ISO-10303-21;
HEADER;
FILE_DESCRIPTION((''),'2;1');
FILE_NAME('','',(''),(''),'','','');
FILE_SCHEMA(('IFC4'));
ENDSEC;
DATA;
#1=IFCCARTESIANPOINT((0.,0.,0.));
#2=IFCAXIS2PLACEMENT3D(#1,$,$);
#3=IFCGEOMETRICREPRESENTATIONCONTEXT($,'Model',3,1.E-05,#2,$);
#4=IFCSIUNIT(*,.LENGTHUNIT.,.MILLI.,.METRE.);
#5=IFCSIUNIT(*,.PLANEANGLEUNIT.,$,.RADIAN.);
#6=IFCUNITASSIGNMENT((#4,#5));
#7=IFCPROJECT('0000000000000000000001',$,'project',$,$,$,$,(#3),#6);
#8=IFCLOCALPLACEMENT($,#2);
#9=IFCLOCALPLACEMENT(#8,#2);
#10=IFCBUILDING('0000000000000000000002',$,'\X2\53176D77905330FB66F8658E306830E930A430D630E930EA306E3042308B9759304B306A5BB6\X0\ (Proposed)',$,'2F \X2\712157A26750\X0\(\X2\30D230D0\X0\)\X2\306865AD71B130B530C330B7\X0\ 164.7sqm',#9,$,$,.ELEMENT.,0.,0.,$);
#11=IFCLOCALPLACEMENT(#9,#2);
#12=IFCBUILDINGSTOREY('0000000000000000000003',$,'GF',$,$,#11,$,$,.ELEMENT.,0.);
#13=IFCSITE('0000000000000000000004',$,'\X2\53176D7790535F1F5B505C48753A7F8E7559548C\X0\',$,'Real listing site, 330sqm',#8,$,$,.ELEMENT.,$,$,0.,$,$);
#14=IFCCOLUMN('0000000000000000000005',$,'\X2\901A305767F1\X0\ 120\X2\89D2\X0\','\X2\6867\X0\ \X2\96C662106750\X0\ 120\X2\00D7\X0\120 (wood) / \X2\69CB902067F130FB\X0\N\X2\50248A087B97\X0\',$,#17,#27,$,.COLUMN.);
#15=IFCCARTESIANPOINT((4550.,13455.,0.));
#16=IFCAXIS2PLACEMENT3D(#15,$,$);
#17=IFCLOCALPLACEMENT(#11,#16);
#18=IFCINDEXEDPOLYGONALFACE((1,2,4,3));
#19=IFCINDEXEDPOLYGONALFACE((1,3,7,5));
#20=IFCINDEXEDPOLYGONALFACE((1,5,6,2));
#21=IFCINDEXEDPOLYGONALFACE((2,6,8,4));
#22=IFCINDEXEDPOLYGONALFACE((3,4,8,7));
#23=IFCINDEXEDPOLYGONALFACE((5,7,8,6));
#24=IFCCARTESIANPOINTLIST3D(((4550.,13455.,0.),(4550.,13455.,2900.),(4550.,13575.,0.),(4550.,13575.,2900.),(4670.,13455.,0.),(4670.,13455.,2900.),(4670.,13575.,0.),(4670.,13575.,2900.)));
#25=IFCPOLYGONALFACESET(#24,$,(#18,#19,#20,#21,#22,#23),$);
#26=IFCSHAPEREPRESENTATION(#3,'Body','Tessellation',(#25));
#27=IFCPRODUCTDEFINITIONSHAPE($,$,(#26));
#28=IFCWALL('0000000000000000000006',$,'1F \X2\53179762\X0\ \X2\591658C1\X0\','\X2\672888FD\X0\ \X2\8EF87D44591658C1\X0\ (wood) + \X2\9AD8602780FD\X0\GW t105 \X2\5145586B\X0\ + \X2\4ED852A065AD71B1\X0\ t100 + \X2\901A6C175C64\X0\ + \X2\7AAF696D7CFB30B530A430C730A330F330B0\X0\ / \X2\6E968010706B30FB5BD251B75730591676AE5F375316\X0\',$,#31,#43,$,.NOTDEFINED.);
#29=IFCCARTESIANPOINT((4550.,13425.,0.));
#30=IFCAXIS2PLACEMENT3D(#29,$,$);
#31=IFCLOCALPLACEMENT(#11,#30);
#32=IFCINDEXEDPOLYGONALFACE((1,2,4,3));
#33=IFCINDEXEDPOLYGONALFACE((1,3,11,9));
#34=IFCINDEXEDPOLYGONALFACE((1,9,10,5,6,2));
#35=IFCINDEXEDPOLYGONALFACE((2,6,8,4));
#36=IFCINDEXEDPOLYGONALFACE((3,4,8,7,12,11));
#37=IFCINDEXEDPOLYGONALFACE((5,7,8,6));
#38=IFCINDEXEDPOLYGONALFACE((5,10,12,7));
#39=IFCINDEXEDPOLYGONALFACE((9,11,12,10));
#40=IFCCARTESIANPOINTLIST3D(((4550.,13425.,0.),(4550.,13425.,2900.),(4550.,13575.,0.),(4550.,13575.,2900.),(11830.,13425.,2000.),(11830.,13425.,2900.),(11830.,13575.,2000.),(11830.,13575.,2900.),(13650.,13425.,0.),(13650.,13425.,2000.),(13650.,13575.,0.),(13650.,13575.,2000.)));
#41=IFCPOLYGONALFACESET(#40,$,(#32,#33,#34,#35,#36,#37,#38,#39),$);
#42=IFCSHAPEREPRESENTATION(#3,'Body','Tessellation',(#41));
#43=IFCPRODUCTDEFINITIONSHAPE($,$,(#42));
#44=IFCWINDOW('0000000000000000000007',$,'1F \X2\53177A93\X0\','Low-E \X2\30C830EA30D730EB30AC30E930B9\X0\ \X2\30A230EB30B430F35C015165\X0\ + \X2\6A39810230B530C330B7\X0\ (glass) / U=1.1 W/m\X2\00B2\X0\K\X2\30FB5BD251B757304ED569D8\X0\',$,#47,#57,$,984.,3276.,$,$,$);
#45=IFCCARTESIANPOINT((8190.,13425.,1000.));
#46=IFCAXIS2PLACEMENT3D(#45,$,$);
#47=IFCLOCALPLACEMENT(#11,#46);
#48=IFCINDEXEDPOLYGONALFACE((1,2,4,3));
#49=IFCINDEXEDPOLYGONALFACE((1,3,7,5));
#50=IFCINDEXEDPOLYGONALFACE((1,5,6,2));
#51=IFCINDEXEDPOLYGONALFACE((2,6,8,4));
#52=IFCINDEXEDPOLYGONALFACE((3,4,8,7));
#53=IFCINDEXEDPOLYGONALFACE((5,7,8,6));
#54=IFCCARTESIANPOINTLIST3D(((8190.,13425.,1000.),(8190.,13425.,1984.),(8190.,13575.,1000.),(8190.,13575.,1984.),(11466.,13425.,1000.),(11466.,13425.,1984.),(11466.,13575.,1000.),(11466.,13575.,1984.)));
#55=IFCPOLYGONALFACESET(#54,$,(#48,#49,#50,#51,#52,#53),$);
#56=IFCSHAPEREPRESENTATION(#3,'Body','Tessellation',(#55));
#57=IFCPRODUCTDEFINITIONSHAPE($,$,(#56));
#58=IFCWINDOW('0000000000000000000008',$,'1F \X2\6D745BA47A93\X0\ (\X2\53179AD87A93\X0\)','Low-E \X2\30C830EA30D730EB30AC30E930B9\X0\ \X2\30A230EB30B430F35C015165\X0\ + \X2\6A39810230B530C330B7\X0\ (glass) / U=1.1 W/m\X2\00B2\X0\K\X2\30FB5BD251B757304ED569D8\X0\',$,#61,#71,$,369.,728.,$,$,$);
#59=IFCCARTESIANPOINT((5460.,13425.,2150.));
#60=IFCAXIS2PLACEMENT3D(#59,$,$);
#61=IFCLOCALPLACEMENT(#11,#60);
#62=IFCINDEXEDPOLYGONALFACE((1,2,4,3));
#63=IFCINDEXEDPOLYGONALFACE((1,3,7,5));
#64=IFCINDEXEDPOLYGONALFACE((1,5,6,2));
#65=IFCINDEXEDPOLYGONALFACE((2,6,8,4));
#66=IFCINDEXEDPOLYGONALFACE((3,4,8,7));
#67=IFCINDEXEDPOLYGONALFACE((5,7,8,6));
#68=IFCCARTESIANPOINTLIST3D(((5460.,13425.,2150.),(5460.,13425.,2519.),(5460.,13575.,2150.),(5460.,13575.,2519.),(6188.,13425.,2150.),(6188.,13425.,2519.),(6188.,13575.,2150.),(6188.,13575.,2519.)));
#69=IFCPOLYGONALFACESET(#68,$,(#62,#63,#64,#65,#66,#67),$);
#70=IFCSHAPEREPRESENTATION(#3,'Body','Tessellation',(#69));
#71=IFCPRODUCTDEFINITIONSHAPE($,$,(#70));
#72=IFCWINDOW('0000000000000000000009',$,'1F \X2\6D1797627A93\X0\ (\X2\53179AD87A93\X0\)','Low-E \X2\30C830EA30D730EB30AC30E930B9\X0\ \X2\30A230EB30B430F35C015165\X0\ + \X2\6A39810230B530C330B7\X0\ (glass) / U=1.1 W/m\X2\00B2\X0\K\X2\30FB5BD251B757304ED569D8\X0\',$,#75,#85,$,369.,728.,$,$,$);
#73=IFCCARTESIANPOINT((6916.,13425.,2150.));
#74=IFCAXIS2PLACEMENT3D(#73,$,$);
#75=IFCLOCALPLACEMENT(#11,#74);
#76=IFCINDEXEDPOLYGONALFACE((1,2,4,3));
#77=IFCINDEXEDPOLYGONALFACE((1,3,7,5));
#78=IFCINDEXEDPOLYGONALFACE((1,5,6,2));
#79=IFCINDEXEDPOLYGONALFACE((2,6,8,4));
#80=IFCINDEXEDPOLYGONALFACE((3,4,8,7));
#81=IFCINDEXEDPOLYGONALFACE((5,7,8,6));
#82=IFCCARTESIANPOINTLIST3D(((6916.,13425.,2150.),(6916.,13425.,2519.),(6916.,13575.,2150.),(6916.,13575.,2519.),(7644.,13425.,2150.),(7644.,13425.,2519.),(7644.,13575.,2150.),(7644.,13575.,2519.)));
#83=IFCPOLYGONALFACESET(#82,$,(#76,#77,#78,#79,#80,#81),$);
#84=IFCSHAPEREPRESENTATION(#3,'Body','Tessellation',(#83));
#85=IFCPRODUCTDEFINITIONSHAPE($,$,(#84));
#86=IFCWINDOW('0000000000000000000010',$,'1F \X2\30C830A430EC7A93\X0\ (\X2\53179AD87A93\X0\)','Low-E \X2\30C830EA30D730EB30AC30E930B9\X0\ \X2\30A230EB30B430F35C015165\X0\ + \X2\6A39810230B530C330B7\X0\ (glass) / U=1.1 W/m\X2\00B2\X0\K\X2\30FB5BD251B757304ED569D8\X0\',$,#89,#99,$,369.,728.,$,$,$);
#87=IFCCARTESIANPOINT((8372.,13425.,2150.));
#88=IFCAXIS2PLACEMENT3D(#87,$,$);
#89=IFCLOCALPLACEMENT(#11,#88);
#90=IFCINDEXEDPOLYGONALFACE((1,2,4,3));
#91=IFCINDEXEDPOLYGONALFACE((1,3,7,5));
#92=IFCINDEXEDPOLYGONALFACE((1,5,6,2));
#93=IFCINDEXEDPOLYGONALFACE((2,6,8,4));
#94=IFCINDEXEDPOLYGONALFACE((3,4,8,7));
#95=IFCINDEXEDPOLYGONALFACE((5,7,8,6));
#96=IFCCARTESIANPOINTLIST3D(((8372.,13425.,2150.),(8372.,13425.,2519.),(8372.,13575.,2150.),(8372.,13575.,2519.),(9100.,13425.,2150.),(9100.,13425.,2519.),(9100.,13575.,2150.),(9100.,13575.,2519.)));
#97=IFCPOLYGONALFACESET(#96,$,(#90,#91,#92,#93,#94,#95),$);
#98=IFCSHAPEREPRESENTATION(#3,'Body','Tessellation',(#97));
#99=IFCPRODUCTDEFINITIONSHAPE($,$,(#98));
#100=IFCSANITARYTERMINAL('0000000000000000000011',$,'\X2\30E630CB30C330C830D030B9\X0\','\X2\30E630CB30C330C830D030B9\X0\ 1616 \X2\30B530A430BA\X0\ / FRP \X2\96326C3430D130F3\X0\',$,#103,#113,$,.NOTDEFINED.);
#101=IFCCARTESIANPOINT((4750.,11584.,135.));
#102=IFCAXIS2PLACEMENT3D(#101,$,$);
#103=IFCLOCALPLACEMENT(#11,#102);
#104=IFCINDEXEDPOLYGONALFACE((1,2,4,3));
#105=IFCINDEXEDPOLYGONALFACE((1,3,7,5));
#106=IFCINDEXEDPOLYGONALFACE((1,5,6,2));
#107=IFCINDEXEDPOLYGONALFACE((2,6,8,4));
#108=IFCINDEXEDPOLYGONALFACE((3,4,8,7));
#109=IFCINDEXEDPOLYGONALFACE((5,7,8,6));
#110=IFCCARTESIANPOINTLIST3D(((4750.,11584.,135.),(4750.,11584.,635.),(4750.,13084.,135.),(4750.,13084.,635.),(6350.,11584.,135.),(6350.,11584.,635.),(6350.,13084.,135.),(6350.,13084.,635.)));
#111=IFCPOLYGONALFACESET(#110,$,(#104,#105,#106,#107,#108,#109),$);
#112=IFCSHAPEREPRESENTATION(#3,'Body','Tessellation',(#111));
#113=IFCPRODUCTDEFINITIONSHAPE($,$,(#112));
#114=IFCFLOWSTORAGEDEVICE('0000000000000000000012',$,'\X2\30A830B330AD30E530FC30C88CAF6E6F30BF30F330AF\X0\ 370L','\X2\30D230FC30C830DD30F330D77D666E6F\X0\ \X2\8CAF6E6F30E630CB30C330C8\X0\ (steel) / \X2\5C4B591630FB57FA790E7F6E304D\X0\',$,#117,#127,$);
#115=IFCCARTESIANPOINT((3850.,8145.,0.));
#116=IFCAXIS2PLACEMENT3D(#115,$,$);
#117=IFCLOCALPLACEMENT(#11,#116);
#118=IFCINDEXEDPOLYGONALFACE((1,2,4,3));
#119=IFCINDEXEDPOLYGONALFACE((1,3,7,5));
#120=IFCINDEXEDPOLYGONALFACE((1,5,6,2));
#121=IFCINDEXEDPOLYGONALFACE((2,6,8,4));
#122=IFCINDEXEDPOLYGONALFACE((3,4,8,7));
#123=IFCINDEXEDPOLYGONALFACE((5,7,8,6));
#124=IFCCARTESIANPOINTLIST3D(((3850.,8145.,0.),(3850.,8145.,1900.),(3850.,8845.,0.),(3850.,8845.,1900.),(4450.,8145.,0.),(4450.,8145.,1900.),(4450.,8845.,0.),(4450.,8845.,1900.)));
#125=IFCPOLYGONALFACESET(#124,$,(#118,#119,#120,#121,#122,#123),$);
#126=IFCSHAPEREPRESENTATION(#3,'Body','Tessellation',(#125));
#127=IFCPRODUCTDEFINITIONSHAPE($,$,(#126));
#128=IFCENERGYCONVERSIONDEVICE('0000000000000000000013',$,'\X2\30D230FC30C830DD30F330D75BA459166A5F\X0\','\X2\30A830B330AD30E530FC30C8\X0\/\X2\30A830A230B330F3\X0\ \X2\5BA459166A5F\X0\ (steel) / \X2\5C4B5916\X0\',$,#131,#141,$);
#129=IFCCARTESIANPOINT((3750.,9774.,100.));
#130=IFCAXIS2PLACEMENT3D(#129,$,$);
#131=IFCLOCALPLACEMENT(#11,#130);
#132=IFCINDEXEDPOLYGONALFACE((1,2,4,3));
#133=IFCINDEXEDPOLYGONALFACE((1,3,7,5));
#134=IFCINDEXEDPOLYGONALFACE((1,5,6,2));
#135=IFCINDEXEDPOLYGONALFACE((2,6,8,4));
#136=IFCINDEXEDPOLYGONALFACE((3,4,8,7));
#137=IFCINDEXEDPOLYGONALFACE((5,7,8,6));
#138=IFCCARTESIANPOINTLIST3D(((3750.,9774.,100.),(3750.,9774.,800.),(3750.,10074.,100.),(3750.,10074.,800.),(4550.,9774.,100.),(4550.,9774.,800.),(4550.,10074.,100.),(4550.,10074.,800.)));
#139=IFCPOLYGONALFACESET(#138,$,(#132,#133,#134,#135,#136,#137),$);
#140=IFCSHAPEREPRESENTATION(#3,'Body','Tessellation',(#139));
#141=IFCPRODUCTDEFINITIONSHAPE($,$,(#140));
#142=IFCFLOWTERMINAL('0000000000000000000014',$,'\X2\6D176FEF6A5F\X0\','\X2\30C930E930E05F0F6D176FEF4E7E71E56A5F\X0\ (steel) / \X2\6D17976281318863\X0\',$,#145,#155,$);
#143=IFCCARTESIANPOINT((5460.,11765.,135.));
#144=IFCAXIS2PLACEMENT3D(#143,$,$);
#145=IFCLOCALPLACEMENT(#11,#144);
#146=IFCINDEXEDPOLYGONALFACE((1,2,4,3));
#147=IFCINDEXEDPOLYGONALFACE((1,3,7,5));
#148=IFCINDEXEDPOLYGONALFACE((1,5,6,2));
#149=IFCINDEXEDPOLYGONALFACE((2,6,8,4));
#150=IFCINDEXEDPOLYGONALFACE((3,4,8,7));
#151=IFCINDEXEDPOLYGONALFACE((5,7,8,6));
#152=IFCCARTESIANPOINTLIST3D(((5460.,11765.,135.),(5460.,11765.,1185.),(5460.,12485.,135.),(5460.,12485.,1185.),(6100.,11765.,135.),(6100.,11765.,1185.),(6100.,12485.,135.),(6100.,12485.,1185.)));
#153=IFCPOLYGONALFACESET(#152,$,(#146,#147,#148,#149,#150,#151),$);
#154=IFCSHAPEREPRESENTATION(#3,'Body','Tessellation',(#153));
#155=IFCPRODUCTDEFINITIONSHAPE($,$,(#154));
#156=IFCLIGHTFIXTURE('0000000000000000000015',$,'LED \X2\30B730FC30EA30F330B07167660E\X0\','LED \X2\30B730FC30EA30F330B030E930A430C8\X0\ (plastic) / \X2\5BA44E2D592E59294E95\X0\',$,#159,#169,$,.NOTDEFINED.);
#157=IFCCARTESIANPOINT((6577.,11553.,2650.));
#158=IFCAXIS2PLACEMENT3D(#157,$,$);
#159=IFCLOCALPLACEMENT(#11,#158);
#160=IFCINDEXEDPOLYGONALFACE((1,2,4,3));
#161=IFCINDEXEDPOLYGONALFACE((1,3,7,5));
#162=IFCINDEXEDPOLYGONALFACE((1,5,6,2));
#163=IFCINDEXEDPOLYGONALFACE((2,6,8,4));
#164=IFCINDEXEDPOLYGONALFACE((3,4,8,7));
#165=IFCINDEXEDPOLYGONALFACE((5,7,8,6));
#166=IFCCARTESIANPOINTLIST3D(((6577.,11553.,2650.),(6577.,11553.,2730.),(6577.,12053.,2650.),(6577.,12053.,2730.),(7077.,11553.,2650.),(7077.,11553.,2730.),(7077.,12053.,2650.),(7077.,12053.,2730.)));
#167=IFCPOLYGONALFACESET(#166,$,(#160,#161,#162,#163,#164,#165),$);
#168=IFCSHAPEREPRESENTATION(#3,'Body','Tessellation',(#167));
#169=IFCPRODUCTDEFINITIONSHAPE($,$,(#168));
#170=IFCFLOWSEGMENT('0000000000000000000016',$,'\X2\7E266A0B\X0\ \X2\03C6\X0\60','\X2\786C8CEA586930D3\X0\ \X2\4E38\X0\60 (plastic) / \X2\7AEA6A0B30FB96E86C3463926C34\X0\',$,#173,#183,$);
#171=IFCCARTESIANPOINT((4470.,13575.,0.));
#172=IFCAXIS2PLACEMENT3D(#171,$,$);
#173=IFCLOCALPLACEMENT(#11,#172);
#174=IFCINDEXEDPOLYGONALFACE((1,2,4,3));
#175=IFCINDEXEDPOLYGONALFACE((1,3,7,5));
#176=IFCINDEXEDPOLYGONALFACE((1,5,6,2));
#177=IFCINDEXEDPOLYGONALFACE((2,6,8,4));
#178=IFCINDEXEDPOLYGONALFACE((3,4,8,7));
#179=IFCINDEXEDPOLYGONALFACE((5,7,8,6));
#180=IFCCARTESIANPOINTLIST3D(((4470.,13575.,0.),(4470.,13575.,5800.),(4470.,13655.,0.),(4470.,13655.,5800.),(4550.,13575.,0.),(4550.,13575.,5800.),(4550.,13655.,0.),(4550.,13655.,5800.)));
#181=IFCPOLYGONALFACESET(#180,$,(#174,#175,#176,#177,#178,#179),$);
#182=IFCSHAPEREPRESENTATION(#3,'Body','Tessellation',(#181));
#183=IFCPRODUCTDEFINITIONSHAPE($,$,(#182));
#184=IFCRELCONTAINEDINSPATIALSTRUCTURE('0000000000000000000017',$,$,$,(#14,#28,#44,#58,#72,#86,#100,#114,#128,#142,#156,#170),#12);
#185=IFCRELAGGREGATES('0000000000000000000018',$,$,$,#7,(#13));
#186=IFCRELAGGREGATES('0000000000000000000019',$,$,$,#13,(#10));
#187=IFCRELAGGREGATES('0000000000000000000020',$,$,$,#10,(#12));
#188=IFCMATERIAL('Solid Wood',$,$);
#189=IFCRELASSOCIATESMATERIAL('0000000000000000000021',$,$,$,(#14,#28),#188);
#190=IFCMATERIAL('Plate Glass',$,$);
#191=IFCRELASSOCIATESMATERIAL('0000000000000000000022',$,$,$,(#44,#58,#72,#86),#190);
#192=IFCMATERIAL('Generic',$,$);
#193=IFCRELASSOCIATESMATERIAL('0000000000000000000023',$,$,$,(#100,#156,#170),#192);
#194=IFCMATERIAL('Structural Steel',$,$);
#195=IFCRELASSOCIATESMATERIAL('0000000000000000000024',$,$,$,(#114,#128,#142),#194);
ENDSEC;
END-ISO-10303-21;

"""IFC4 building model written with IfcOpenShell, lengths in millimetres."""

from ifc_helpers import new_model, si_unit, frame, frame_2d, origin, place, context, project, spatial, rectangle, extrude, material, element, fill, save


model = new_model("IFC4")

# Units and contexts
model_context = context("Model", 3, precision=1e-05, world=origin())
ifc_project = project(units=[si_unit("LENGTHUNIT", "METRE", prefix="MILLI"), si_unit("PLANEANGLEUNIT", "RADIAN")], contexts=[model_context])

# Site, building, storey
site_placement = place(None, origin())
site = spatial("IfcSite", under=ifc_project, at=site_placement, Name="北海道弟子屈町美留和", ObjectType="Real listing site, 330sqm", CompositionType="ELEMENT", RefElevation=0.0)
building_placement = place(site_placement, origin())
building = spatial("IfcBuilding", under=site, at=building_placement, Name="北海道・書斎とライブラリのある静かな家 (Proposed)", ObjectType="2F 無垢材(ヒバ)と断熱サッシ 164.7sqm", CompositionType="ELEMENT", ElevationOfRefHeight=0.0, ElevationOfTerrain=0.0)
storey_placement = place(building_placement, origin())
storey = spatial("IfcBuildingStorey", under=building, at=storey_placement, Name="GF", CompositionType="ELEMENT", Elevation=0.0)

# Column
ifc_material_1 = material(Name="Solid Wood")
column_1_placement = place(storey_placement, frame((4550.0, 13455.0, 0.0)))
element("IfcColumn", 1, at=column_1_placement, inside=storey, material=ifc_material_1, Name="通し柱 120角", Description="桧 集成材 120×120 (wood) / 構造柱・N値計算", PredefinedType="COLUMN", context=model_context, shape_type="SweptSolid", body=[
    extrude(rectangle(XDim=120.0, YDim=120.0, at=frame_2d((60.0, 60.0))), frame((4550.0, 13455.0, 0.0)), (0.0, 0.0, 1.0), 2900.0),
])

# Wall, openings, windows
wall_1_placement = place(storey_placement, frame((4550.0, 13425.0, 0.0)))
wall_1 = element("IfcWall", 2, at=wall_1_placement, inside=storey, material=ifc_material_1, Name="1F 北面 外壁", Description="木製 軸組外壁 (wood) + 高性能GW t105 充填 + 付加断熱 t100 + 通気層 + 窯業系サイディング / 準耐火・寒冷地外皮強化", PredefinedType="NOTDEFINED", context=model_context, shape_type="SweptSolid", body=[
    extrude(rectangle(XDim=9100.0, YDim=150.0, at=frame_2d((4550.0, 75.0))), frame((4550.0, 13425.0, 0.0)), (0.0, 0.0, 1.0), 2900.0),
])
opening_1_placement = place(storey_placement, frame((8190.0, 13425.0, 1000.0)))
opening_1 = element("IfcOpeningElement", 3, at=opening_1_placement, cuts=wall_1, PredefinedType="NOTDEFINED", context=model_context, shape_type="SweptSolid", body=[
    extrude(rectangle(XDim=3276.0, YDim=150.0, at=frame_2d((1638.0, 75.0))), frame((8190.0, 13425.0, 1000.0)), (0.0, 0.0, 1.0), 984.0),
])
opening_2_placement = place(storey_placement, frame((5460.0, 13425.0, 2150.0)))
opening_2 = element("IfcOpeningElement", 4, at=opening_2_placement, cuts=wall_1, PredefinedType="NOTDEFINED", context=model_context, shape_type="SweptSolid", body=[
    extrude(rectangle(XDim=728.0, YDim=150.0, at=frame_2d((364.0, 75.0))), frame((5460.0, 13425.0, 2150.0)), (0.0, 0.0, 1.0), 369.0),
])
opening_3_placement = place(storey_placement, frame((6916.0, 13425.0, 2150.0)))
opening_3 = element("IfcOpeningElement", 5, at=opening_3_placement, cuts=wall_1, PredefinedType="NOTDEFINED", context=model_context, shape_type="SweptSolid", body=[
    extrude(rectangle(XDim=728.0, YDim=150.0, at=frame_2d((364.0, 75.0))), frame((6916.0, 13425.0, 2150.0)), (0.0, 0.0, 1.0), 369.0),
])
opening_4_placement = place(storey_placement, frame((8372.0, 13425.0, 2150.0)))
opening_4 = element("IfcOpeningElement", 6, at=opening_4_placement, cuts=wall_1, PredefinedType="NOTDEFINED", context=model_context, shape_type="SweptSolid", body=[
    extrude(rectangle(XDim=728.0, YDim=150.0, at=frame_2d((364.0, 75.0))), frame((8372.0, 13425.0, 2150.0)), (0.0, 0.0, 1.0), 369.0),
])
ifc_material_2 = material(Name="Plate Glass")
window_1_placement = place(storey_placement, frame((8190.0, 13425.0, 1000.0)))
window_1 = element("IfcWindow", 7, at=window_1_placement, inside=storey, material=ifc_material_2, Name="1F 北窓", Description="Low-E トリプルガラス アルゴン封入 + 樹脂サッシ (glass) / U=1.1 W/m²K・寒冷地仕様", OverallHeight=984.0, OverallWidth=3276.0, context=model_context, shape_type="SweptSolid", body=[
    extrude(rectangle(XDim=3276.0, YDim=150.0, at=frame_2d((1638.0, 75.0))), frame((8190.0, 13425.0, 1000.0)), (0.0, 0.0, 1.0), 984.0),
])
fill(opening_1, window_1)
window_2_placement = place(storey_placement, frame((5460.0, 13425.0, 2150.0)))
window_2 = element("IfcWindow", 8, at=window_2_placement, inside=storey, material=ifc_material_2, Name="1F 浴室窓 (北高窓)", Description="Low-E トリプルガラス アルゴン封入 + 樹脂サッシ (glass) / U=1.1 W/m²K・寒冷地仕様", OverallHeight=369.0, OverallWidth=728.0, context=model_context, shape_type="SweptSolid", body=[
    extrude(rectangle(XDim=728.0, YDim=150.0, at=frame_2d((364.0, 75.0))), frame((5460.0, 13425.0, 2150.0)), (0.0, 0.0, 1.0), 369.0),
])
fill(opening_2, window_2)
window_3_placement = place(storey_placement, frame((6916.0, 13425.0, 2150.0)))
window_3 = element("IfcWindow", 9, at=window_3_placement, inside=storey, material=ifc_material_2, Name="1F 洗面窓 (北高窓)", Description="Low-E トリプルガラス アルゴン封入 + 樹脂サッシ (glass) / U=1.1 W/m²K・寒冷地仕様", OverallHeight=369.0, OverallWidth=728.0, context=model_context, shape_type="SweptSolid", body=[
    extrude(rectangle(XDim=728.0, YDim=150.0, at=frame_2d((364.0, 75.0))), frame((6916.0, 13425.0, 2150.0)), (0.0, 0.0, 1.0), 369.0),
])
fill(opening_3, window_3)
window_4_placement = place(storey_placement, frame((8372.0, 13425.0, 2150.0)))
window_4 = element("IfcWindow", 10, at=window_4_placement, inside=storey, material=ifc_material_2, Name="1F トイレ窓 (北高窓)", Description="Low-E トリプルガラス アルゴン封入 + 樹脂サッシ (glass) / U=1.1 W/m²K・寒冷地仕様", OverallHeight=369.0, OverallWidth=728.0, context=model_context, shape_type="SweptSolid", body=[
    extrude(rectangle(XDim=728.0, YDim=150.0, at=frame_2d((364.0, 75.0))), frame((8372.0, 13425.0, 2150.0)), (0.0, 0.0, 1.0), 369.0),
])
fill(opening_4, window_4)

# Sanitary terminal
ifc_material_3 = material(Name="Generic")
sanitary_terminal_placement = place(storey_placement, frame((4750.0, 11584.0, 135.0)))
element("IfcSanitaryTerminal", 11, at=sanitary_terminal_placement, inside=storey, material=ifc_material_3, Name="ユニットバス", Description="ユニットバス 1616 サイズ / FRP 防水パン", PredefinedType="NOTDEFINED", context=model_context, shape_type="SweptSolid", body=[
    extrude(rectangle(XDim=1600.0, YDim=1500.0, at=frame_2d((800.0, 750.0))), frame((4750.0, 11584.0, 135.0)), (0.0, 0.0, 1.0), 500.0),
])

# Flow storage device
ifc_material_4 = material(Name="Structural Steel")
flow_storage_device_placement = place(storey_placement, frame((3850.0, 8145.0, 0.0)))
element("IfcFlowStorageDevice", 12, at=flow_storage_device_placement, inside=storey, material=ifc_material_4, Name="エコキュート貯湯タンク 370L", Description="ヒートポンプ給湯 貯湯ユニット (steel) / 屋外・基礎置き", context=model_context, shape_type="SweptSolid", body=[
    extrude(rectangle(XDim=600.0, YDim=700.0, at=frame_2d((300.0, 350.0))), frame((3850.0, 8145.0, 0.0)), (0.0, 0.0, 1.0), 1900.0),
])

# Energy conversion device
energy_conversion_device_placement = place(storey_placement, frame((3750.0, 9774.0, 100.0)))
element("IfcEnergyConversionDevice", 13, at=energy_conversion_device_placement, inside=storey, material=ifc_material_4, Name="ヒートポンプ室外機", Description="エコキュート/エアコン 室外機 (steel) / 屋外", context=model_context, shape_type="SweptSolid", body=[
    extrude(rectangle(XDim=800.0, YDim=300.0, at=frame_2d((400.0, 150.0))), frame((3750.0, 9774.0, 100.0)), (0.0, 0.0, 1.0), 700.0),
])

# Flow terminal
flow_terminal_placement = place(storey_placement, frame((5460.0, 11765.0, 135.0)))
element("IfcFlowTerminal", 14, at=flow_terminal_placement, inside=storey, material=ifc_material_4, Name="洗濯機", Description="ドラム式洗濯乾燥機 (steel) / 洗面脱衣", context=model_context, shape_type="SweptSolid", body=[
    extrude(rectangle(XDim=640.0, YDim=720.0, at=frame_2d((320.0, 360.0))), frame((5460.0, 11765.0, 135.0)), (0.0, 0.0, 1.0), 1050.0),
])

# Light fixture
light_fixture_placement = place(storey_placement, frame((6577.0, 11553.0, 2650.0)))
element("IfcLightFixture", 15, at=light_fixture_placement, inside=storey, material=ifc_material_3, Name="LED シーリング照明", Description="LED シーリングライト (plastic) / 室中央天井", PredefinedType="NOTDEFINED", context=model_context, shape_type="SweptSolid", body=[
    extrude(rectangle(XDim=500.0, YDim=500.0, at=frame_2d((250.0, 250.0))), frame((6577.0, 11553.0, 2650.0)), (0.0, 0.0, 1.0), 80.0),
])

# Flow segment
flow_segment_placement = place(storey_placement, frame((4470.0, 13575.0, 0.0)))
element("IfcFlowSegment", 16, at=flow_segment_placement, inside=storey, material=ifc_material_3, Name="縦樋 φ60", Description="硬質塩ビ 丸60 (plastic) / 竪樋・雨水排水", context=model_context, shape_type="SweptSolid", body=[
    extrude(rectangle(XDim=80.0, YDim=80.0, at=frame_2d((40.0, 40.0))), frame((4470.0, 13575.0, 0.0)), (0.0, 0.0, 1.0), 5800.0),
])

save(model, "model.ifc")
